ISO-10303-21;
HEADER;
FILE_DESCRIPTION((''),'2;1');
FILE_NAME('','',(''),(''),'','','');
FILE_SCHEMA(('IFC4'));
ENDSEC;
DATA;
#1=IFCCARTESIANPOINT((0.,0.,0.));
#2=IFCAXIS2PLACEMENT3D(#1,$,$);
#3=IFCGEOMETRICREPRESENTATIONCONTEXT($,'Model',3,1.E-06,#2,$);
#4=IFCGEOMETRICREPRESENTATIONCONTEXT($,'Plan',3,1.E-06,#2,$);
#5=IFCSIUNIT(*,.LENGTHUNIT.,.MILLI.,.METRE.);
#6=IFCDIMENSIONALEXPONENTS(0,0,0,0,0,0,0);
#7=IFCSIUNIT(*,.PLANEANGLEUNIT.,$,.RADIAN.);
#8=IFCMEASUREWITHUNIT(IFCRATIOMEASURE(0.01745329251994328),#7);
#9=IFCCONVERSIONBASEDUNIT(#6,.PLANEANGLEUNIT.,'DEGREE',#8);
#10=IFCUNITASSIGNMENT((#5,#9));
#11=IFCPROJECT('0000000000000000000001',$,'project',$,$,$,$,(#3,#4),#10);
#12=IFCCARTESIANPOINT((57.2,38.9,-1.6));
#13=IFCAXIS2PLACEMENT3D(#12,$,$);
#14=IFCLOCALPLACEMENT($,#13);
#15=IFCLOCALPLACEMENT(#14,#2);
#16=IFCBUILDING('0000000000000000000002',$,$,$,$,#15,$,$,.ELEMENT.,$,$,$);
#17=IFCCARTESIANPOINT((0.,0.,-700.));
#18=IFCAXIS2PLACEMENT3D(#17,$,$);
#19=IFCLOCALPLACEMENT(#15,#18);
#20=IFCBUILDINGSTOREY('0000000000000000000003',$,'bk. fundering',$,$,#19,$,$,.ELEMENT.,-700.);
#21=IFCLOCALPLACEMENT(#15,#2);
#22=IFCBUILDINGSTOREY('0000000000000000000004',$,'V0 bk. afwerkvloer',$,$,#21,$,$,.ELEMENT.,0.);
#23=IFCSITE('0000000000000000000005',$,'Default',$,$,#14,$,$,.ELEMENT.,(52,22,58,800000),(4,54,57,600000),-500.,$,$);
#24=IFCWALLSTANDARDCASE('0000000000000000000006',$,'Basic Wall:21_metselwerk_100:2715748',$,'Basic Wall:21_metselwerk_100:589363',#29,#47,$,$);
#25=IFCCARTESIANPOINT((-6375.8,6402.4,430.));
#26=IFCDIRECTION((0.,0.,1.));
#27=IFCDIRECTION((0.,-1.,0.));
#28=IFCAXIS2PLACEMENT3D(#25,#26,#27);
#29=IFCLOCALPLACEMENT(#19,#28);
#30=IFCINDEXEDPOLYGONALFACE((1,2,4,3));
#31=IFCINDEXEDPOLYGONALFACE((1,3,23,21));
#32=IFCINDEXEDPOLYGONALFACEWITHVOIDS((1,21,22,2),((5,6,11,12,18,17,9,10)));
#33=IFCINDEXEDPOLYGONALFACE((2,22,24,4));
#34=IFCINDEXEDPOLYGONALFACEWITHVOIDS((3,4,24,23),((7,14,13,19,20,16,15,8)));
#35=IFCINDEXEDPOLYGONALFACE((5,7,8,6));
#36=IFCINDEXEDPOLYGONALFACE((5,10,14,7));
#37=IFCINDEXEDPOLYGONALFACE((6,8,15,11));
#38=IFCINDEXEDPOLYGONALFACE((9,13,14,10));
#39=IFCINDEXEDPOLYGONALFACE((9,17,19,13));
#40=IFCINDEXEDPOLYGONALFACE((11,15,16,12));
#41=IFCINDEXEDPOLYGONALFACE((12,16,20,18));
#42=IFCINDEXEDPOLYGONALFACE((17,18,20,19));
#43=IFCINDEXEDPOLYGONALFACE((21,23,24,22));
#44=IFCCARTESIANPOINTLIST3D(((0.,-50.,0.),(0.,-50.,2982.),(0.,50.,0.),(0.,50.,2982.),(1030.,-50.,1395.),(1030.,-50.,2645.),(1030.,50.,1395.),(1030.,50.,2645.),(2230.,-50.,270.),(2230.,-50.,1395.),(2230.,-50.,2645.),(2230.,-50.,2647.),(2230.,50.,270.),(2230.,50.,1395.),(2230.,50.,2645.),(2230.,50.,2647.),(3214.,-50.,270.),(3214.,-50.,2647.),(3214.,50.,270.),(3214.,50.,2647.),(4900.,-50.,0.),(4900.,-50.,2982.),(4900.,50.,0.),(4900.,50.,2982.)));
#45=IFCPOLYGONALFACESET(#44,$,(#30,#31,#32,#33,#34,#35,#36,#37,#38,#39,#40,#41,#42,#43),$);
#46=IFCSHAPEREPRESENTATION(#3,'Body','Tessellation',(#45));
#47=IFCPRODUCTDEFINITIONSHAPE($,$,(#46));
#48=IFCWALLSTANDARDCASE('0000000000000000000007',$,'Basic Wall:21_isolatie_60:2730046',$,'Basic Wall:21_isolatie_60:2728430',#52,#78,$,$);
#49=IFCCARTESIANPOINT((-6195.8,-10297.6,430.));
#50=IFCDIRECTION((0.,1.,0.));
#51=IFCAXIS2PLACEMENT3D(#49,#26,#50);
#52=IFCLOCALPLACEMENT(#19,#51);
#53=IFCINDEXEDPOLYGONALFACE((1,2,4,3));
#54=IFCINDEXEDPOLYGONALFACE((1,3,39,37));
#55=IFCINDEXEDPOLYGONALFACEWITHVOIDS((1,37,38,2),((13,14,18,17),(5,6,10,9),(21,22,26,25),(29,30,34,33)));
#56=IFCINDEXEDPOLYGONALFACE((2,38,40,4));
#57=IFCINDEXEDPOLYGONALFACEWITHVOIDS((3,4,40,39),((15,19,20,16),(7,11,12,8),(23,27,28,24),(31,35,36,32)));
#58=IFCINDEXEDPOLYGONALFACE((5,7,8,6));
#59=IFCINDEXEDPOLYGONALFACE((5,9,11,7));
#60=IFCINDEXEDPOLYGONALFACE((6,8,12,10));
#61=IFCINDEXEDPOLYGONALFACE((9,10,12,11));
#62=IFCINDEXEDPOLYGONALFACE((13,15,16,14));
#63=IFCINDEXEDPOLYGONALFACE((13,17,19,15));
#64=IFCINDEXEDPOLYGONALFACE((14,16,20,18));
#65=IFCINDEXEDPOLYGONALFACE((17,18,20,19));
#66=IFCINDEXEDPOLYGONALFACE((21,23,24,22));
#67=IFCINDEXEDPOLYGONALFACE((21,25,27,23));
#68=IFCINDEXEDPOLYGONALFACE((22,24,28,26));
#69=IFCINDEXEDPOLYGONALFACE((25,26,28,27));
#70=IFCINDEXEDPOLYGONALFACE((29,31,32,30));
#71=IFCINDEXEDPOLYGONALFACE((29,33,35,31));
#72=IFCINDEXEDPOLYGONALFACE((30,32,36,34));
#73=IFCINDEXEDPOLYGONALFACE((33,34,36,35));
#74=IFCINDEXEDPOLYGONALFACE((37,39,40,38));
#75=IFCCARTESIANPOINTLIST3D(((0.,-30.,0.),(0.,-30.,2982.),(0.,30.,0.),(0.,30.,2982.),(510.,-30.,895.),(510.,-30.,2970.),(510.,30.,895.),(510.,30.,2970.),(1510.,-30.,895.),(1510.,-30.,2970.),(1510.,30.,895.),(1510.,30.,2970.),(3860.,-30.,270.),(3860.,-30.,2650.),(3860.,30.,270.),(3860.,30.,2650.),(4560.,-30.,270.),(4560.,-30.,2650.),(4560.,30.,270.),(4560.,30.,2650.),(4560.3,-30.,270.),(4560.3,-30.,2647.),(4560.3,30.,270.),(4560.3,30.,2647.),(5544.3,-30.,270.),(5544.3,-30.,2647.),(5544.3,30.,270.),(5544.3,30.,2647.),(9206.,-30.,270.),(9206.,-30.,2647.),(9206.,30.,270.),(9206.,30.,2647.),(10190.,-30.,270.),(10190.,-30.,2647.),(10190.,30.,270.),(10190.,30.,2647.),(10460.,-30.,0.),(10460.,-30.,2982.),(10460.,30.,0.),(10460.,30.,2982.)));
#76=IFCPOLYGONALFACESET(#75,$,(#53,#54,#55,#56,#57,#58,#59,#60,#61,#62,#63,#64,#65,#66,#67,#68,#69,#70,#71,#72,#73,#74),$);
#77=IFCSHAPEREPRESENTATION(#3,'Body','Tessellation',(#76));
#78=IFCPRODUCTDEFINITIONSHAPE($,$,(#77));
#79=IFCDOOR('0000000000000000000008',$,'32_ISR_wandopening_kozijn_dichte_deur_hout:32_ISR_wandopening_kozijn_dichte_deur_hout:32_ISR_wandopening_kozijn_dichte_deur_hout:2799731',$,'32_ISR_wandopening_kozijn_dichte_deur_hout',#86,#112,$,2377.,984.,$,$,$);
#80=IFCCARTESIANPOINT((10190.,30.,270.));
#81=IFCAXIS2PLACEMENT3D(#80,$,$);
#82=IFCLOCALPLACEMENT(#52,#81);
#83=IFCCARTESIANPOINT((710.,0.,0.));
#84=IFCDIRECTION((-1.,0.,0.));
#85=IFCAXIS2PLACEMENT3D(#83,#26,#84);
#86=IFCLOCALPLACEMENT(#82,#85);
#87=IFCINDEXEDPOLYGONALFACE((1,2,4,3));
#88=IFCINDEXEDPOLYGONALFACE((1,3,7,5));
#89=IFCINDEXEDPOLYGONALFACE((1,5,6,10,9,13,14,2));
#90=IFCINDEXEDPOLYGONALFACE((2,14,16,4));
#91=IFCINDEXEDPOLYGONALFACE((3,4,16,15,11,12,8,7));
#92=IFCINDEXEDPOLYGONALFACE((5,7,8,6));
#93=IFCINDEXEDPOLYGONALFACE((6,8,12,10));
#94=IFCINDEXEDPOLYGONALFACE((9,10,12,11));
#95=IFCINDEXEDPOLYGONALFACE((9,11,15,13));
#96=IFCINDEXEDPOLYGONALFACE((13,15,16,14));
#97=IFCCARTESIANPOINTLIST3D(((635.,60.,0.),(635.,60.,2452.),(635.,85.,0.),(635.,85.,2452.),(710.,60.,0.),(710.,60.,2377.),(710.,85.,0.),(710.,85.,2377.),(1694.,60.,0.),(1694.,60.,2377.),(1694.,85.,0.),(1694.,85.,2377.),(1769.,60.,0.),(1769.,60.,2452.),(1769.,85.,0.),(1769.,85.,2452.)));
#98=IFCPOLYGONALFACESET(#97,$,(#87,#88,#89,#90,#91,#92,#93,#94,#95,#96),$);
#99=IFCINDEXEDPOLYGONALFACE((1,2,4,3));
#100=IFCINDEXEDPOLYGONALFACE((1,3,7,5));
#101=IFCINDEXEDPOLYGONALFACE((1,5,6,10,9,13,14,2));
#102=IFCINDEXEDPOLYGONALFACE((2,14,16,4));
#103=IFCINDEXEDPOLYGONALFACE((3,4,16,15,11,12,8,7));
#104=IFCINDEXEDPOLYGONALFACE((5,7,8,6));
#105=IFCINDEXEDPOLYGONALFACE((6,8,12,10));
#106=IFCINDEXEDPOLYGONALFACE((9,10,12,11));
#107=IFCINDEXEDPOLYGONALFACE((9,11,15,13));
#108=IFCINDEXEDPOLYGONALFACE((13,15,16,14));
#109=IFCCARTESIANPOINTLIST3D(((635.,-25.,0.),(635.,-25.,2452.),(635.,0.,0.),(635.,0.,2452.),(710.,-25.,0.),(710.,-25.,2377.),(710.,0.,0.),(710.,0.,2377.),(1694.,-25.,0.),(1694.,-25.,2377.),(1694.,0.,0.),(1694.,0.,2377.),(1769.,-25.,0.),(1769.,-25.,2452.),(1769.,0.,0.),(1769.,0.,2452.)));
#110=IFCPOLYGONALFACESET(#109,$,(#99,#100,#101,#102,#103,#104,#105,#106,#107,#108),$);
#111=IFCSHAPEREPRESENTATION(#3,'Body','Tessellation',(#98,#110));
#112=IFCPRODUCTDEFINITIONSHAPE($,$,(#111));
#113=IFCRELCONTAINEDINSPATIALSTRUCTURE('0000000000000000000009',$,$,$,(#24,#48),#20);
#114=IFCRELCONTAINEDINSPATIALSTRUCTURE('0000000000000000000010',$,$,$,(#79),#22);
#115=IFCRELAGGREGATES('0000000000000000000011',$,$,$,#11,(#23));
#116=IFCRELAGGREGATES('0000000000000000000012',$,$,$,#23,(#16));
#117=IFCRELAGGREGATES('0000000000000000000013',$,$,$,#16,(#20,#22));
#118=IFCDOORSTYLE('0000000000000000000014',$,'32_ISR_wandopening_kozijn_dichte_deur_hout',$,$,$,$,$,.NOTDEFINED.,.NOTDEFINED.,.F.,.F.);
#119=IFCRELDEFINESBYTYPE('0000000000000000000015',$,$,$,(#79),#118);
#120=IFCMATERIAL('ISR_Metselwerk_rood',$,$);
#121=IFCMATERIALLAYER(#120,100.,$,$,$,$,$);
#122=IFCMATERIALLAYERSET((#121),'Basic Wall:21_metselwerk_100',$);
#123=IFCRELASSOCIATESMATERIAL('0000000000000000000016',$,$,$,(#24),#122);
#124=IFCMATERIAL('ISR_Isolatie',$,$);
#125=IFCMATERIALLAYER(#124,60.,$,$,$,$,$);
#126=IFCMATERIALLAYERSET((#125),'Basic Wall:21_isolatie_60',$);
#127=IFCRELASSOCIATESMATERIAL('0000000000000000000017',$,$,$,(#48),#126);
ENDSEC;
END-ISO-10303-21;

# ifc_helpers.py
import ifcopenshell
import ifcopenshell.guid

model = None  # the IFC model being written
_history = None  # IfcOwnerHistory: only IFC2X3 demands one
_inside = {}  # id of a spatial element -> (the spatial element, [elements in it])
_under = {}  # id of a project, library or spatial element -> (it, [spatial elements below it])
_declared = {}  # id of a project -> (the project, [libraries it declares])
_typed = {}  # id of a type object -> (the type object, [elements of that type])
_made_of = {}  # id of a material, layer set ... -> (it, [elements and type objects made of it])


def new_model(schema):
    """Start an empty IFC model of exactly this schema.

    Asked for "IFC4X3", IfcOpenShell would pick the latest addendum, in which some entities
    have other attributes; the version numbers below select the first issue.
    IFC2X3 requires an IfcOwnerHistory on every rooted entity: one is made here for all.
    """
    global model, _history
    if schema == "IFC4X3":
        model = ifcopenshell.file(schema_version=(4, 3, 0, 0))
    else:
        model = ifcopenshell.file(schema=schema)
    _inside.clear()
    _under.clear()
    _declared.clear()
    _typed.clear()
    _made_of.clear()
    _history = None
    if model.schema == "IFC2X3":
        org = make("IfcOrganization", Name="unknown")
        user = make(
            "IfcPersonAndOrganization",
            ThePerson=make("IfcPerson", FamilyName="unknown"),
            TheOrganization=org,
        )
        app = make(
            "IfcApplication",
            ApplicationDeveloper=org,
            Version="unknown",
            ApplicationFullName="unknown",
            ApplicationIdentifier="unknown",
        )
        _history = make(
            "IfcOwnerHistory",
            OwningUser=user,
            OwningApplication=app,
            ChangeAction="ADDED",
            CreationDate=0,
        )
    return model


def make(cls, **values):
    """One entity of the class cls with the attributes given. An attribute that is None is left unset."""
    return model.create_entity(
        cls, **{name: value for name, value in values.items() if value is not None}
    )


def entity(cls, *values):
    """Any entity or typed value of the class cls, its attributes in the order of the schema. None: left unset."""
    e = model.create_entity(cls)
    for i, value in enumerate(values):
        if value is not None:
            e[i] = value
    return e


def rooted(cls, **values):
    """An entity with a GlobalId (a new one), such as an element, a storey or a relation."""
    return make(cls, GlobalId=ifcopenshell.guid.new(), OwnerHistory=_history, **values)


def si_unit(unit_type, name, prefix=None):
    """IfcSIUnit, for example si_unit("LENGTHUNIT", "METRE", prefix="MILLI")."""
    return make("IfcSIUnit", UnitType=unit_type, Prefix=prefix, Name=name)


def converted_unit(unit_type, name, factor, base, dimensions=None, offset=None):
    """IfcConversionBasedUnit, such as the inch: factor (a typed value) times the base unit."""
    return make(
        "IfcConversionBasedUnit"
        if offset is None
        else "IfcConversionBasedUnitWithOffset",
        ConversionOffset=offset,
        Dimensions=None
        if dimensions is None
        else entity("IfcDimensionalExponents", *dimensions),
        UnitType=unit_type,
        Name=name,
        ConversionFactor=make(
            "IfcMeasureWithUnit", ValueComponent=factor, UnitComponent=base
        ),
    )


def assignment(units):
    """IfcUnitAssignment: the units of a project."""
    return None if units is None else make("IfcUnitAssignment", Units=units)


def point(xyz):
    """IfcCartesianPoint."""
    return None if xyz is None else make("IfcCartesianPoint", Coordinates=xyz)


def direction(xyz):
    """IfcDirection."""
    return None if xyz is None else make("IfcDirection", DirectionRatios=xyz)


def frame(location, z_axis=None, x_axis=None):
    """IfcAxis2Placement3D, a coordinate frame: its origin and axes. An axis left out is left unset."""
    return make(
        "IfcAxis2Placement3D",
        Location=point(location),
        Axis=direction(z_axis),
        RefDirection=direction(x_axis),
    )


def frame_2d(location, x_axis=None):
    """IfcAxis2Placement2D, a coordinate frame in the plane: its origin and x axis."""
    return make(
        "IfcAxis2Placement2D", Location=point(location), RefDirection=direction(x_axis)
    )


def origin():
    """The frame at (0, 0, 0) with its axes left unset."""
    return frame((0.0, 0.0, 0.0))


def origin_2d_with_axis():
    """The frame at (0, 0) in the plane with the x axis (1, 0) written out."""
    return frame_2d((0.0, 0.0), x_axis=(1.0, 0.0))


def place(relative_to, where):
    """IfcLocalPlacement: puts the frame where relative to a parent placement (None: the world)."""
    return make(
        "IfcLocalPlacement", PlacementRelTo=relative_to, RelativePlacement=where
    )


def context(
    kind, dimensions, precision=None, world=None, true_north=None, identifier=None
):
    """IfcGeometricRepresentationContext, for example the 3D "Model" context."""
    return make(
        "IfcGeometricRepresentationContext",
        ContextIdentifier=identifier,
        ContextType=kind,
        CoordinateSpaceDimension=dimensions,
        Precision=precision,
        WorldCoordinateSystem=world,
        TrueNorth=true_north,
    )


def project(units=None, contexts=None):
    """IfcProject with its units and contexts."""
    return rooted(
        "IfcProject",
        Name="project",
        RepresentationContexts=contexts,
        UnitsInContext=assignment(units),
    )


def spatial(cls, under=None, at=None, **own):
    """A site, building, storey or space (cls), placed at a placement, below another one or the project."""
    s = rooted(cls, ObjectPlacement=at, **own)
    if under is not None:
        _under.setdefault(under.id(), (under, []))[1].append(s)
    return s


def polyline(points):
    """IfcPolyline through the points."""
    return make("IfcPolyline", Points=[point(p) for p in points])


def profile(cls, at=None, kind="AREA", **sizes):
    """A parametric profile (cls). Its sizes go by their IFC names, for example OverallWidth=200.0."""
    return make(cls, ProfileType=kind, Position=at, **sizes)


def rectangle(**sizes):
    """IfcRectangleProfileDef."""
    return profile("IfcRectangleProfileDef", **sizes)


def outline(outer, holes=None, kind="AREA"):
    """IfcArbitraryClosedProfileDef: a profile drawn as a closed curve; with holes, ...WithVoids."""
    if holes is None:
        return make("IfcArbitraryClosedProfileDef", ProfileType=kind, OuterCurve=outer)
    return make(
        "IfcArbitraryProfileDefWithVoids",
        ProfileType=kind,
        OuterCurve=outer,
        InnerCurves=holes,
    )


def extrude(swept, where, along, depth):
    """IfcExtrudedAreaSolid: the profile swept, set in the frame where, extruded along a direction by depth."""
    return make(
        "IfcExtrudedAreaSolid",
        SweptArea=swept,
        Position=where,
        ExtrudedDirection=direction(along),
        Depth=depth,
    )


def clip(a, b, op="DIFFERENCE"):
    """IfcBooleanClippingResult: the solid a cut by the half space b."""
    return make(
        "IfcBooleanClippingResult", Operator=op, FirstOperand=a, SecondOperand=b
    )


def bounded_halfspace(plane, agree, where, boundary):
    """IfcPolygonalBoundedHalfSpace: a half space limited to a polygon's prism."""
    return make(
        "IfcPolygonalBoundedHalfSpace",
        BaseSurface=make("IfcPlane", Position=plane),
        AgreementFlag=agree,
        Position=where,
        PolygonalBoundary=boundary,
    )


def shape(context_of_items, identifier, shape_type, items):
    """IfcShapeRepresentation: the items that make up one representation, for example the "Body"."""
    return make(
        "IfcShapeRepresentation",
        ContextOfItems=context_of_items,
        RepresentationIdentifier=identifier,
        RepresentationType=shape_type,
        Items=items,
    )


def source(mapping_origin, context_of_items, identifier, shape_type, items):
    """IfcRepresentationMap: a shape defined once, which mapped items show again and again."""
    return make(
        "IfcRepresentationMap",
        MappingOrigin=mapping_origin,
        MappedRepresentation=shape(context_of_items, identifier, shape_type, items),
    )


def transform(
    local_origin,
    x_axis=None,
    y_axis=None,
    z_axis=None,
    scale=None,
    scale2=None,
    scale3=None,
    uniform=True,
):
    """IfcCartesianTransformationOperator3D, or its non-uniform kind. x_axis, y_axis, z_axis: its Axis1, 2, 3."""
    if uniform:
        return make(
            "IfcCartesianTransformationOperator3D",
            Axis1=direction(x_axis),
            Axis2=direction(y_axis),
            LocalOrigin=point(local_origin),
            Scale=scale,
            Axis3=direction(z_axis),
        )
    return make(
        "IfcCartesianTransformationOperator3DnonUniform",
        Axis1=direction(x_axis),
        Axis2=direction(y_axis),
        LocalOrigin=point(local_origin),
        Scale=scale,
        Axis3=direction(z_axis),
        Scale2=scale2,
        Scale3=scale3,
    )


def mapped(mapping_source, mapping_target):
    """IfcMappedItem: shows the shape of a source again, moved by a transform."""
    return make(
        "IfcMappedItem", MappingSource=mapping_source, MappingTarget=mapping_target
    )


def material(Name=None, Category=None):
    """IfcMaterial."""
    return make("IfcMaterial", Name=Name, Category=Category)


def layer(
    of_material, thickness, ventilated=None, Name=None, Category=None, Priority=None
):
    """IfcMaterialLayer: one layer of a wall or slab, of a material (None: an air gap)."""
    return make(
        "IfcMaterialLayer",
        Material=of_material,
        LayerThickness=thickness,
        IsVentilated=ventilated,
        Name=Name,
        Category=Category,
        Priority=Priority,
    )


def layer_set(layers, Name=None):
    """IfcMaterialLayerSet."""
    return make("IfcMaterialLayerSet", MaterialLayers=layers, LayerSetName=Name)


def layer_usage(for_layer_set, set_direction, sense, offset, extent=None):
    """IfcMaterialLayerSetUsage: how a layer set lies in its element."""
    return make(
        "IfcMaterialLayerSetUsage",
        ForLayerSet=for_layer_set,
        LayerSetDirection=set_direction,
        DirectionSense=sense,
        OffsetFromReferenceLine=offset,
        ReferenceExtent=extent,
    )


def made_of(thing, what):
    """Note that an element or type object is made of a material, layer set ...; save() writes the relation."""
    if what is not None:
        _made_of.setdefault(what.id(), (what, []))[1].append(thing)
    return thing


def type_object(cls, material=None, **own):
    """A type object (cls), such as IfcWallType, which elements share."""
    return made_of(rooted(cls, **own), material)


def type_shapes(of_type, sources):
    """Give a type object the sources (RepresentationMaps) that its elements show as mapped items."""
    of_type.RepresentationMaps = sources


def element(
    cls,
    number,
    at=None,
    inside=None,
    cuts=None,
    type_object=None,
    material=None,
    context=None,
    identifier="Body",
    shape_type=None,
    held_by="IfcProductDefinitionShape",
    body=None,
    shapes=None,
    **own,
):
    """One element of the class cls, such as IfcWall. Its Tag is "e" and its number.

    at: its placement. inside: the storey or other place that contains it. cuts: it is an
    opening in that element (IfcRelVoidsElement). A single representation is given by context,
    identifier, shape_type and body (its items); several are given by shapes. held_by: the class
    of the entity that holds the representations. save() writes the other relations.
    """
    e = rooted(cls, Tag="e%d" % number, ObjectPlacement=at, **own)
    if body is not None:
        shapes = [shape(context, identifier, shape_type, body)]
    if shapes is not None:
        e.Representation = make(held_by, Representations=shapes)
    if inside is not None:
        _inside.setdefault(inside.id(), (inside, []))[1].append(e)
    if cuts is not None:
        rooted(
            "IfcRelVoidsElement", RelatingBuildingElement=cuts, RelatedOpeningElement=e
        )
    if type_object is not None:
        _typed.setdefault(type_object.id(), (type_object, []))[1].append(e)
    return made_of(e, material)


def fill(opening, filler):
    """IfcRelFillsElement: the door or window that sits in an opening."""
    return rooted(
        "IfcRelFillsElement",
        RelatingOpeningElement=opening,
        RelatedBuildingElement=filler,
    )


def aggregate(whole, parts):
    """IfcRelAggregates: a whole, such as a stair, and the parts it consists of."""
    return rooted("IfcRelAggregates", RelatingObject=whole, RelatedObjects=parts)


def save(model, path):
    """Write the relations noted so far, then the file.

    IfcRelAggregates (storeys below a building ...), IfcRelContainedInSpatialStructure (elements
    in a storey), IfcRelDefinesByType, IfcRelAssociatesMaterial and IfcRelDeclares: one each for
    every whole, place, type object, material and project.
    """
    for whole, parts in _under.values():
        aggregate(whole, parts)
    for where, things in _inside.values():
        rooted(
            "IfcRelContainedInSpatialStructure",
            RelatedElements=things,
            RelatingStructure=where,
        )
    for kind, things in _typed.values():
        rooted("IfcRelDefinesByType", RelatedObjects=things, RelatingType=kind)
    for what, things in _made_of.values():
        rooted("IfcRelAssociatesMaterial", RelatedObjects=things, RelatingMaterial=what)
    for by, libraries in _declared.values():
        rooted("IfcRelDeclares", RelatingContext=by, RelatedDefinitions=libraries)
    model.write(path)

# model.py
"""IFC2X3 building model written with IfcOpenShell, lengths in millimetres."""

from ifc_helpers import new_model, entity, si_unit, converted_unit, frame, frame_2d, origin, origin_2d_with_axis, place, context, project, spatial, polyline, rectangle, outline, extrude, clip, bounded_halfspace, source, transform, mapped, material, layer, layer_set, layer_usage, type_object, type_shapes, element, fill, save


model = new_model("IFC2X3")

# Units and contexts
model_context = context("Model", 3, precision=1e-06, world=origin())
plan_context = context("Plan", 3, precision=1e-06, world=origin())
ifc_project = project(units=[si_unit("LENGTHUNIT", "METRE", prefix="MILLI"), converted_unit("PLANEANGLEUNIT", "DEGREE", entity("IfcRatioMeasure", 0.01745329251994328), si_unit("PLANEANGLEUNIT", "RADIAN"), dimensions=[0, 0, 0, 0, 0, 0, 0])], contexts=[model_context, plan_context])

# Site, building, storey
site_placement = place(None, frame((57.2, 38.9, -1.6)))
site = spatial("IfcSite", under=ifc_project, at=site_placement, Name="Default", CompositionType="ELEMENT", RefLatitude=(52, 22, 58, 800000), RefLongitude=(4, 54, 57, 600000), RefElevation=-500.0)
building_placement = place(site_placement, origin())
building = spatial("IfcBuilding", under=site, at=building_placement, CompositionType="ELEMENT")
storey_1_placement = place(building_placement, frame((0.0, 0.0, -700.0)))
storey_1 = spatial("IfcBuildingStorey", under=building, at=storey_1_placement, Name="bk. fundering", CompositionType="ELEMENT", Elevation=-700.0)

# Shared definitions
ifc_material_1 = material(Name="ISR_Metselwerk_rood")
ifc_layer_1 = layer(ifc_material_1, 100.0)
ifc_layer_set_1 = layer_set([ifc_layer_1], Name="Basic Wall:21_metselwerk_100")

# Walls, openings
ifc_layer_usage_1 = layer_usage(ifc_layer_set_1, "AXIS2", "NEGATIVE", 50.0)
wall_1_placement = place(storey_1_placement, frame((-6375.8, 6402.4, 430.0), z_axis=(0.0, 0.0, 1.0), x_axis=(0.0, -1.0, 0.0)))
wall_1 = element("IfcWallStandardCase", 1, at=wall_1_placement, inside=storey_1, material=ifc_layer_usage_1, Name="Basic Wall:21_metselwerk_100:2715748", ObjectType="Basic Wall:21_metselwerk_100:589363", context=model_context, shape_type="SweptSolid", body=[
    extrude(rectangle(XDim=4900.0, YDim=100.0, at=frame_2d((2450.0, 0.0), x_axis=(-1.0, 0.0))), origin(), (0.0, 0.0, 1.0), 2982.0),
])
opening_1_placement = place(wall_1_placement, origin())
element("IfcOpeningElement", 2, at=opening_1_placement, cuts=wall_1, ObjectType="Opening", context=model_context, shape_type="SweptSolid", body=[
    extrude(rectangle(XDim=1250.0, YDim=1200.0, at=origin_2d_with_axis()), frame((1630.0, -202.4, 2020.0), z_axis=(0.0, 1.0, 0.0), x_axis=(0.0, 0.0, 1.0)), (0.0, 0.0, 1.0), 404.8),
])
opening_2_placement = place(wall_1_placement, origin())
element("IfcOpeningElement", 3, at=opening_2_placement, cuts=wall_1, ObjectType="Opening", context=model_context, shape_type="SweptSolid", body=[
    extrude(rectangle(XDim=2377.0, YDim=984.0, at=frame_2d((0.0, 0.0), x_axis=(0.0, 1.0))), frame((2722.0, -1394.0, 1458.5), z_axis=(0.0, 1.0, 0.0), x_axis=(-1.0, 0.0, 0.0)), (0.0, 0.0, 1.0), 3048.0),
])
ifc_material_2 = material(Name="ISR_Isolatie")
ifc_layer_2 = layer(ifc_material_2, 60.0)
ifc_layer_set_2 = layer_set([ifc_layer_2], Name="Basic Wall:21_isolatie_60")
ifc_layer_usage_2 = layer_usage(ifc_layer_set_2, "AXIS2", "NEGATIVE", 30.0)
wall_2_placement = place(storey_1_placement, frame((-6195.8, -10297.6, 430.0), z_axis=(0.0, 0.0, 1.0), x_axis=(0.0, 1.0, 0.0)))
wall_2 = element("IfcWallStandardCase", 4, at=wall_2_placement, inside=storey_1, material=ifc_layer_usage_2, Name="Basic Wall:21_isolatie_60:2730046", ObjectType="Basic Wall:21_isolatie_60:2728430", context=model_context, shape_type="Clipping", body=[
    clip(extrude(rectangle(XDim=10460.0, YDim=60.0, at=frame_2d((5230.0, 0.0), x_axis=(-1.0, 0.0))), origin(), (0.0, 0.0, 1.0), 2982.0), bounded_halfspace(frame((9070.0, -30.0, 2982.0), z_axis=(0.0, 0.0, -1.0), x_axis=(-1.0, 0.0, 0.0)), True, frame((9070.0, -30.0, 2982.0)), polyline([(0.0, 0.0), (1390.0, 0.0), (1390.0, 60.0), (0.0, 60.0), (0.0, 0.0)]))),
])
opening_3_placement = place(wall_2_placement, origin())
element("IfcOpeningElement", 5, at=opening_3_placement, cuts=wall_2, ObjectType="Opening", context=model_context, shape_type="SweptSolid", body=[
    extrude(rectangle(XDim=2380.0, YDim=700.0, at=origin_2d_with_axis()), frame((4210.0, -182.4, 1460.0), z_axis=(0.0, 1.0, 0.0), x_axis=(0.0, 0.0, 1.0)), (0.0, 0.0, 1.0), 364.8),
])
opening_4_placement = place(wall_2_placement, origin())
element("IfcOpeningElement", 6, at=opening_4_placement, cuts=wall_2, ObjectType="Opening", context=model_context, shape_type="SweptSolid", body=[
    extrude(rectangle(XDim=2075.0, YDim=1000.0, at=frame_2d((0.0, 0.0), x_axis=(0.0, 1.0))), frame((1010.0, -182.4, 1932.5), z_axis=(0.0, 1.0, 0.0), x_axis=(-1.0, 0.0, 0.0)), (0.0, 0.0, 1.0), 364.8),
])
opening_5_placement = place(wall_2_placement, origin())
element("IfcOpeningElement", 7, at=opening_5_placement, cuts=wall_2, ObjectType="Opening", context=model_context, shape_type="SweptSolid", body=[
    extrude(rectangle(XDim=2377.0, YDim=984.0, at=frame_2d((0.0, 0.0), x_axis=(0.0, 1.0))), frame((5052.3, -1494.0, 1458.5), z_axis=(0.0, 1.0, 0.0), x_axis=(-1.0, 0.0, 0.0)), (0.0, 0.0, 1.0), 3048.0),
])
opening_6_placement = place(wall_2_placement, origin())
element("IfcOpeningElement", 8, at=opening_6_placement, cuts=wall_2, ObjectType="Opening", context=model_context, shape_type="SweptSolid", body=[
    extrude(rectangle(XDim=2377.0, YDim=984.0, at=origin_2d_with_axis()), frame((11120.0, -1394.0, 1458.5), z_axis=(0.0, 1.0, 0.0), x_axis=(0.0, 0.0, 1.0)), (0.0, 0.0, 1.0), 3048.0),
])
opening_7_placement = place(wall_2_placement, frame((10190.0, 30.0, 270.0)))
opening_7 = element("IfcOpeningElement", 9, at=opening_7_placement, cuts=wall_2, ObjectType="Opening", context=model_context, shape_type="SweptSolid", body=[
    extrude(rectangle(XDim=2377.0, YDim=984.0, at=frame_2d((1188.5, 492.0), x_axis=(1.0, 0.0))), frame((0.0, 0.0, 0.0), z_axis=(0.0, -1.0, 0.0), x_axis=(0.0, 0.0, 1.0)), (0.0, 0.0, 1.0), 60.0),
])

# Shared definitions
storey_2_placement = place(building_placement, origin())
storey_2 = spatial("IfcBuildingStorey", under=building, at=storey_2_placement, Name="V0 bk. afwerkvloer", CompositionType="ELEMENT", Elevation=0.0)

# Door
door_style = type_object("IfcDoorStyle", Name="32_ISR_wandopening_kozijn_dichte_deur_hout", ConstructionType="NOTDEFINED", OperationType="NOTDEFINED", ParameterTakesPrecedence=False, Sizeable=False)
shared_shape = source(origin(), model_context, "Body", "SweptSolid", [
    extrude(outline(polyline([(-1169.7, 492.0), (1207.2, 492.0), (1207.2, 567.0), (-1244.7, 567.0), (-1244.7, -567.0), (1207.2, -567.0), (1207.2, -492.0), (-1169.7, -492.0), (-1169.7, 492.0)])), frame((1202.0, 85.0, 1207.2), z_axis=(0.0, -1.0, 0.0), x_axis=(0.0, 0.0, -1.0)), (0.0, 0.0, 1.0), 25.0),
    extrude(outline(polyline([(-567.0, -1244.7), (567.0, -1244.7), (567.0, 1207.2), (492.0, 1207.2), (492.0, -1169.7), (-492.0, -1169.7), (-492.0, 1207.2), (-567.0, 1207.2), (-567.0, -1244.7)])), frame((1202.0, 0.0, 1207.2), z_axis=(0.0, -1.0, 0.0), x_axis=(-1.0, 0.0, 0.0)), (0.0, 0.0, 1.0), 25.0),
])
type_shapes(door_style, [shared_shape])
door_placement = place(opening_7_placement, frame((710.0, 0.0, 0.0), z_axis=(0.0, 0.0, 1.0), x_axis=(-1.0, 0.0, 0.0)))
door = element("IfcDoor", 10, at=door_placement, inside=storey_2, type_object=door_style, Name="32_ISR_wandopening_kozijn_dichte_deur_hout:32_ISR_wandopening_kozijn_dichte_deur_hout:32_ISR_wandopening_kozijn_dichte_deur_hout:2799731", ObjectType="32_ISR_wandopening_kozijn_dichte_deur_hout", OverallHeight=2377.0, OverallWidth=984.0, context=model_context, shape_type="MappedRepresentation", body=[
    mapped(shared_shape, transform((0.0, 0.0, 0.0), scale=1.0)),
])
fill(opening_7, door)

save(model, "model.ifc")
